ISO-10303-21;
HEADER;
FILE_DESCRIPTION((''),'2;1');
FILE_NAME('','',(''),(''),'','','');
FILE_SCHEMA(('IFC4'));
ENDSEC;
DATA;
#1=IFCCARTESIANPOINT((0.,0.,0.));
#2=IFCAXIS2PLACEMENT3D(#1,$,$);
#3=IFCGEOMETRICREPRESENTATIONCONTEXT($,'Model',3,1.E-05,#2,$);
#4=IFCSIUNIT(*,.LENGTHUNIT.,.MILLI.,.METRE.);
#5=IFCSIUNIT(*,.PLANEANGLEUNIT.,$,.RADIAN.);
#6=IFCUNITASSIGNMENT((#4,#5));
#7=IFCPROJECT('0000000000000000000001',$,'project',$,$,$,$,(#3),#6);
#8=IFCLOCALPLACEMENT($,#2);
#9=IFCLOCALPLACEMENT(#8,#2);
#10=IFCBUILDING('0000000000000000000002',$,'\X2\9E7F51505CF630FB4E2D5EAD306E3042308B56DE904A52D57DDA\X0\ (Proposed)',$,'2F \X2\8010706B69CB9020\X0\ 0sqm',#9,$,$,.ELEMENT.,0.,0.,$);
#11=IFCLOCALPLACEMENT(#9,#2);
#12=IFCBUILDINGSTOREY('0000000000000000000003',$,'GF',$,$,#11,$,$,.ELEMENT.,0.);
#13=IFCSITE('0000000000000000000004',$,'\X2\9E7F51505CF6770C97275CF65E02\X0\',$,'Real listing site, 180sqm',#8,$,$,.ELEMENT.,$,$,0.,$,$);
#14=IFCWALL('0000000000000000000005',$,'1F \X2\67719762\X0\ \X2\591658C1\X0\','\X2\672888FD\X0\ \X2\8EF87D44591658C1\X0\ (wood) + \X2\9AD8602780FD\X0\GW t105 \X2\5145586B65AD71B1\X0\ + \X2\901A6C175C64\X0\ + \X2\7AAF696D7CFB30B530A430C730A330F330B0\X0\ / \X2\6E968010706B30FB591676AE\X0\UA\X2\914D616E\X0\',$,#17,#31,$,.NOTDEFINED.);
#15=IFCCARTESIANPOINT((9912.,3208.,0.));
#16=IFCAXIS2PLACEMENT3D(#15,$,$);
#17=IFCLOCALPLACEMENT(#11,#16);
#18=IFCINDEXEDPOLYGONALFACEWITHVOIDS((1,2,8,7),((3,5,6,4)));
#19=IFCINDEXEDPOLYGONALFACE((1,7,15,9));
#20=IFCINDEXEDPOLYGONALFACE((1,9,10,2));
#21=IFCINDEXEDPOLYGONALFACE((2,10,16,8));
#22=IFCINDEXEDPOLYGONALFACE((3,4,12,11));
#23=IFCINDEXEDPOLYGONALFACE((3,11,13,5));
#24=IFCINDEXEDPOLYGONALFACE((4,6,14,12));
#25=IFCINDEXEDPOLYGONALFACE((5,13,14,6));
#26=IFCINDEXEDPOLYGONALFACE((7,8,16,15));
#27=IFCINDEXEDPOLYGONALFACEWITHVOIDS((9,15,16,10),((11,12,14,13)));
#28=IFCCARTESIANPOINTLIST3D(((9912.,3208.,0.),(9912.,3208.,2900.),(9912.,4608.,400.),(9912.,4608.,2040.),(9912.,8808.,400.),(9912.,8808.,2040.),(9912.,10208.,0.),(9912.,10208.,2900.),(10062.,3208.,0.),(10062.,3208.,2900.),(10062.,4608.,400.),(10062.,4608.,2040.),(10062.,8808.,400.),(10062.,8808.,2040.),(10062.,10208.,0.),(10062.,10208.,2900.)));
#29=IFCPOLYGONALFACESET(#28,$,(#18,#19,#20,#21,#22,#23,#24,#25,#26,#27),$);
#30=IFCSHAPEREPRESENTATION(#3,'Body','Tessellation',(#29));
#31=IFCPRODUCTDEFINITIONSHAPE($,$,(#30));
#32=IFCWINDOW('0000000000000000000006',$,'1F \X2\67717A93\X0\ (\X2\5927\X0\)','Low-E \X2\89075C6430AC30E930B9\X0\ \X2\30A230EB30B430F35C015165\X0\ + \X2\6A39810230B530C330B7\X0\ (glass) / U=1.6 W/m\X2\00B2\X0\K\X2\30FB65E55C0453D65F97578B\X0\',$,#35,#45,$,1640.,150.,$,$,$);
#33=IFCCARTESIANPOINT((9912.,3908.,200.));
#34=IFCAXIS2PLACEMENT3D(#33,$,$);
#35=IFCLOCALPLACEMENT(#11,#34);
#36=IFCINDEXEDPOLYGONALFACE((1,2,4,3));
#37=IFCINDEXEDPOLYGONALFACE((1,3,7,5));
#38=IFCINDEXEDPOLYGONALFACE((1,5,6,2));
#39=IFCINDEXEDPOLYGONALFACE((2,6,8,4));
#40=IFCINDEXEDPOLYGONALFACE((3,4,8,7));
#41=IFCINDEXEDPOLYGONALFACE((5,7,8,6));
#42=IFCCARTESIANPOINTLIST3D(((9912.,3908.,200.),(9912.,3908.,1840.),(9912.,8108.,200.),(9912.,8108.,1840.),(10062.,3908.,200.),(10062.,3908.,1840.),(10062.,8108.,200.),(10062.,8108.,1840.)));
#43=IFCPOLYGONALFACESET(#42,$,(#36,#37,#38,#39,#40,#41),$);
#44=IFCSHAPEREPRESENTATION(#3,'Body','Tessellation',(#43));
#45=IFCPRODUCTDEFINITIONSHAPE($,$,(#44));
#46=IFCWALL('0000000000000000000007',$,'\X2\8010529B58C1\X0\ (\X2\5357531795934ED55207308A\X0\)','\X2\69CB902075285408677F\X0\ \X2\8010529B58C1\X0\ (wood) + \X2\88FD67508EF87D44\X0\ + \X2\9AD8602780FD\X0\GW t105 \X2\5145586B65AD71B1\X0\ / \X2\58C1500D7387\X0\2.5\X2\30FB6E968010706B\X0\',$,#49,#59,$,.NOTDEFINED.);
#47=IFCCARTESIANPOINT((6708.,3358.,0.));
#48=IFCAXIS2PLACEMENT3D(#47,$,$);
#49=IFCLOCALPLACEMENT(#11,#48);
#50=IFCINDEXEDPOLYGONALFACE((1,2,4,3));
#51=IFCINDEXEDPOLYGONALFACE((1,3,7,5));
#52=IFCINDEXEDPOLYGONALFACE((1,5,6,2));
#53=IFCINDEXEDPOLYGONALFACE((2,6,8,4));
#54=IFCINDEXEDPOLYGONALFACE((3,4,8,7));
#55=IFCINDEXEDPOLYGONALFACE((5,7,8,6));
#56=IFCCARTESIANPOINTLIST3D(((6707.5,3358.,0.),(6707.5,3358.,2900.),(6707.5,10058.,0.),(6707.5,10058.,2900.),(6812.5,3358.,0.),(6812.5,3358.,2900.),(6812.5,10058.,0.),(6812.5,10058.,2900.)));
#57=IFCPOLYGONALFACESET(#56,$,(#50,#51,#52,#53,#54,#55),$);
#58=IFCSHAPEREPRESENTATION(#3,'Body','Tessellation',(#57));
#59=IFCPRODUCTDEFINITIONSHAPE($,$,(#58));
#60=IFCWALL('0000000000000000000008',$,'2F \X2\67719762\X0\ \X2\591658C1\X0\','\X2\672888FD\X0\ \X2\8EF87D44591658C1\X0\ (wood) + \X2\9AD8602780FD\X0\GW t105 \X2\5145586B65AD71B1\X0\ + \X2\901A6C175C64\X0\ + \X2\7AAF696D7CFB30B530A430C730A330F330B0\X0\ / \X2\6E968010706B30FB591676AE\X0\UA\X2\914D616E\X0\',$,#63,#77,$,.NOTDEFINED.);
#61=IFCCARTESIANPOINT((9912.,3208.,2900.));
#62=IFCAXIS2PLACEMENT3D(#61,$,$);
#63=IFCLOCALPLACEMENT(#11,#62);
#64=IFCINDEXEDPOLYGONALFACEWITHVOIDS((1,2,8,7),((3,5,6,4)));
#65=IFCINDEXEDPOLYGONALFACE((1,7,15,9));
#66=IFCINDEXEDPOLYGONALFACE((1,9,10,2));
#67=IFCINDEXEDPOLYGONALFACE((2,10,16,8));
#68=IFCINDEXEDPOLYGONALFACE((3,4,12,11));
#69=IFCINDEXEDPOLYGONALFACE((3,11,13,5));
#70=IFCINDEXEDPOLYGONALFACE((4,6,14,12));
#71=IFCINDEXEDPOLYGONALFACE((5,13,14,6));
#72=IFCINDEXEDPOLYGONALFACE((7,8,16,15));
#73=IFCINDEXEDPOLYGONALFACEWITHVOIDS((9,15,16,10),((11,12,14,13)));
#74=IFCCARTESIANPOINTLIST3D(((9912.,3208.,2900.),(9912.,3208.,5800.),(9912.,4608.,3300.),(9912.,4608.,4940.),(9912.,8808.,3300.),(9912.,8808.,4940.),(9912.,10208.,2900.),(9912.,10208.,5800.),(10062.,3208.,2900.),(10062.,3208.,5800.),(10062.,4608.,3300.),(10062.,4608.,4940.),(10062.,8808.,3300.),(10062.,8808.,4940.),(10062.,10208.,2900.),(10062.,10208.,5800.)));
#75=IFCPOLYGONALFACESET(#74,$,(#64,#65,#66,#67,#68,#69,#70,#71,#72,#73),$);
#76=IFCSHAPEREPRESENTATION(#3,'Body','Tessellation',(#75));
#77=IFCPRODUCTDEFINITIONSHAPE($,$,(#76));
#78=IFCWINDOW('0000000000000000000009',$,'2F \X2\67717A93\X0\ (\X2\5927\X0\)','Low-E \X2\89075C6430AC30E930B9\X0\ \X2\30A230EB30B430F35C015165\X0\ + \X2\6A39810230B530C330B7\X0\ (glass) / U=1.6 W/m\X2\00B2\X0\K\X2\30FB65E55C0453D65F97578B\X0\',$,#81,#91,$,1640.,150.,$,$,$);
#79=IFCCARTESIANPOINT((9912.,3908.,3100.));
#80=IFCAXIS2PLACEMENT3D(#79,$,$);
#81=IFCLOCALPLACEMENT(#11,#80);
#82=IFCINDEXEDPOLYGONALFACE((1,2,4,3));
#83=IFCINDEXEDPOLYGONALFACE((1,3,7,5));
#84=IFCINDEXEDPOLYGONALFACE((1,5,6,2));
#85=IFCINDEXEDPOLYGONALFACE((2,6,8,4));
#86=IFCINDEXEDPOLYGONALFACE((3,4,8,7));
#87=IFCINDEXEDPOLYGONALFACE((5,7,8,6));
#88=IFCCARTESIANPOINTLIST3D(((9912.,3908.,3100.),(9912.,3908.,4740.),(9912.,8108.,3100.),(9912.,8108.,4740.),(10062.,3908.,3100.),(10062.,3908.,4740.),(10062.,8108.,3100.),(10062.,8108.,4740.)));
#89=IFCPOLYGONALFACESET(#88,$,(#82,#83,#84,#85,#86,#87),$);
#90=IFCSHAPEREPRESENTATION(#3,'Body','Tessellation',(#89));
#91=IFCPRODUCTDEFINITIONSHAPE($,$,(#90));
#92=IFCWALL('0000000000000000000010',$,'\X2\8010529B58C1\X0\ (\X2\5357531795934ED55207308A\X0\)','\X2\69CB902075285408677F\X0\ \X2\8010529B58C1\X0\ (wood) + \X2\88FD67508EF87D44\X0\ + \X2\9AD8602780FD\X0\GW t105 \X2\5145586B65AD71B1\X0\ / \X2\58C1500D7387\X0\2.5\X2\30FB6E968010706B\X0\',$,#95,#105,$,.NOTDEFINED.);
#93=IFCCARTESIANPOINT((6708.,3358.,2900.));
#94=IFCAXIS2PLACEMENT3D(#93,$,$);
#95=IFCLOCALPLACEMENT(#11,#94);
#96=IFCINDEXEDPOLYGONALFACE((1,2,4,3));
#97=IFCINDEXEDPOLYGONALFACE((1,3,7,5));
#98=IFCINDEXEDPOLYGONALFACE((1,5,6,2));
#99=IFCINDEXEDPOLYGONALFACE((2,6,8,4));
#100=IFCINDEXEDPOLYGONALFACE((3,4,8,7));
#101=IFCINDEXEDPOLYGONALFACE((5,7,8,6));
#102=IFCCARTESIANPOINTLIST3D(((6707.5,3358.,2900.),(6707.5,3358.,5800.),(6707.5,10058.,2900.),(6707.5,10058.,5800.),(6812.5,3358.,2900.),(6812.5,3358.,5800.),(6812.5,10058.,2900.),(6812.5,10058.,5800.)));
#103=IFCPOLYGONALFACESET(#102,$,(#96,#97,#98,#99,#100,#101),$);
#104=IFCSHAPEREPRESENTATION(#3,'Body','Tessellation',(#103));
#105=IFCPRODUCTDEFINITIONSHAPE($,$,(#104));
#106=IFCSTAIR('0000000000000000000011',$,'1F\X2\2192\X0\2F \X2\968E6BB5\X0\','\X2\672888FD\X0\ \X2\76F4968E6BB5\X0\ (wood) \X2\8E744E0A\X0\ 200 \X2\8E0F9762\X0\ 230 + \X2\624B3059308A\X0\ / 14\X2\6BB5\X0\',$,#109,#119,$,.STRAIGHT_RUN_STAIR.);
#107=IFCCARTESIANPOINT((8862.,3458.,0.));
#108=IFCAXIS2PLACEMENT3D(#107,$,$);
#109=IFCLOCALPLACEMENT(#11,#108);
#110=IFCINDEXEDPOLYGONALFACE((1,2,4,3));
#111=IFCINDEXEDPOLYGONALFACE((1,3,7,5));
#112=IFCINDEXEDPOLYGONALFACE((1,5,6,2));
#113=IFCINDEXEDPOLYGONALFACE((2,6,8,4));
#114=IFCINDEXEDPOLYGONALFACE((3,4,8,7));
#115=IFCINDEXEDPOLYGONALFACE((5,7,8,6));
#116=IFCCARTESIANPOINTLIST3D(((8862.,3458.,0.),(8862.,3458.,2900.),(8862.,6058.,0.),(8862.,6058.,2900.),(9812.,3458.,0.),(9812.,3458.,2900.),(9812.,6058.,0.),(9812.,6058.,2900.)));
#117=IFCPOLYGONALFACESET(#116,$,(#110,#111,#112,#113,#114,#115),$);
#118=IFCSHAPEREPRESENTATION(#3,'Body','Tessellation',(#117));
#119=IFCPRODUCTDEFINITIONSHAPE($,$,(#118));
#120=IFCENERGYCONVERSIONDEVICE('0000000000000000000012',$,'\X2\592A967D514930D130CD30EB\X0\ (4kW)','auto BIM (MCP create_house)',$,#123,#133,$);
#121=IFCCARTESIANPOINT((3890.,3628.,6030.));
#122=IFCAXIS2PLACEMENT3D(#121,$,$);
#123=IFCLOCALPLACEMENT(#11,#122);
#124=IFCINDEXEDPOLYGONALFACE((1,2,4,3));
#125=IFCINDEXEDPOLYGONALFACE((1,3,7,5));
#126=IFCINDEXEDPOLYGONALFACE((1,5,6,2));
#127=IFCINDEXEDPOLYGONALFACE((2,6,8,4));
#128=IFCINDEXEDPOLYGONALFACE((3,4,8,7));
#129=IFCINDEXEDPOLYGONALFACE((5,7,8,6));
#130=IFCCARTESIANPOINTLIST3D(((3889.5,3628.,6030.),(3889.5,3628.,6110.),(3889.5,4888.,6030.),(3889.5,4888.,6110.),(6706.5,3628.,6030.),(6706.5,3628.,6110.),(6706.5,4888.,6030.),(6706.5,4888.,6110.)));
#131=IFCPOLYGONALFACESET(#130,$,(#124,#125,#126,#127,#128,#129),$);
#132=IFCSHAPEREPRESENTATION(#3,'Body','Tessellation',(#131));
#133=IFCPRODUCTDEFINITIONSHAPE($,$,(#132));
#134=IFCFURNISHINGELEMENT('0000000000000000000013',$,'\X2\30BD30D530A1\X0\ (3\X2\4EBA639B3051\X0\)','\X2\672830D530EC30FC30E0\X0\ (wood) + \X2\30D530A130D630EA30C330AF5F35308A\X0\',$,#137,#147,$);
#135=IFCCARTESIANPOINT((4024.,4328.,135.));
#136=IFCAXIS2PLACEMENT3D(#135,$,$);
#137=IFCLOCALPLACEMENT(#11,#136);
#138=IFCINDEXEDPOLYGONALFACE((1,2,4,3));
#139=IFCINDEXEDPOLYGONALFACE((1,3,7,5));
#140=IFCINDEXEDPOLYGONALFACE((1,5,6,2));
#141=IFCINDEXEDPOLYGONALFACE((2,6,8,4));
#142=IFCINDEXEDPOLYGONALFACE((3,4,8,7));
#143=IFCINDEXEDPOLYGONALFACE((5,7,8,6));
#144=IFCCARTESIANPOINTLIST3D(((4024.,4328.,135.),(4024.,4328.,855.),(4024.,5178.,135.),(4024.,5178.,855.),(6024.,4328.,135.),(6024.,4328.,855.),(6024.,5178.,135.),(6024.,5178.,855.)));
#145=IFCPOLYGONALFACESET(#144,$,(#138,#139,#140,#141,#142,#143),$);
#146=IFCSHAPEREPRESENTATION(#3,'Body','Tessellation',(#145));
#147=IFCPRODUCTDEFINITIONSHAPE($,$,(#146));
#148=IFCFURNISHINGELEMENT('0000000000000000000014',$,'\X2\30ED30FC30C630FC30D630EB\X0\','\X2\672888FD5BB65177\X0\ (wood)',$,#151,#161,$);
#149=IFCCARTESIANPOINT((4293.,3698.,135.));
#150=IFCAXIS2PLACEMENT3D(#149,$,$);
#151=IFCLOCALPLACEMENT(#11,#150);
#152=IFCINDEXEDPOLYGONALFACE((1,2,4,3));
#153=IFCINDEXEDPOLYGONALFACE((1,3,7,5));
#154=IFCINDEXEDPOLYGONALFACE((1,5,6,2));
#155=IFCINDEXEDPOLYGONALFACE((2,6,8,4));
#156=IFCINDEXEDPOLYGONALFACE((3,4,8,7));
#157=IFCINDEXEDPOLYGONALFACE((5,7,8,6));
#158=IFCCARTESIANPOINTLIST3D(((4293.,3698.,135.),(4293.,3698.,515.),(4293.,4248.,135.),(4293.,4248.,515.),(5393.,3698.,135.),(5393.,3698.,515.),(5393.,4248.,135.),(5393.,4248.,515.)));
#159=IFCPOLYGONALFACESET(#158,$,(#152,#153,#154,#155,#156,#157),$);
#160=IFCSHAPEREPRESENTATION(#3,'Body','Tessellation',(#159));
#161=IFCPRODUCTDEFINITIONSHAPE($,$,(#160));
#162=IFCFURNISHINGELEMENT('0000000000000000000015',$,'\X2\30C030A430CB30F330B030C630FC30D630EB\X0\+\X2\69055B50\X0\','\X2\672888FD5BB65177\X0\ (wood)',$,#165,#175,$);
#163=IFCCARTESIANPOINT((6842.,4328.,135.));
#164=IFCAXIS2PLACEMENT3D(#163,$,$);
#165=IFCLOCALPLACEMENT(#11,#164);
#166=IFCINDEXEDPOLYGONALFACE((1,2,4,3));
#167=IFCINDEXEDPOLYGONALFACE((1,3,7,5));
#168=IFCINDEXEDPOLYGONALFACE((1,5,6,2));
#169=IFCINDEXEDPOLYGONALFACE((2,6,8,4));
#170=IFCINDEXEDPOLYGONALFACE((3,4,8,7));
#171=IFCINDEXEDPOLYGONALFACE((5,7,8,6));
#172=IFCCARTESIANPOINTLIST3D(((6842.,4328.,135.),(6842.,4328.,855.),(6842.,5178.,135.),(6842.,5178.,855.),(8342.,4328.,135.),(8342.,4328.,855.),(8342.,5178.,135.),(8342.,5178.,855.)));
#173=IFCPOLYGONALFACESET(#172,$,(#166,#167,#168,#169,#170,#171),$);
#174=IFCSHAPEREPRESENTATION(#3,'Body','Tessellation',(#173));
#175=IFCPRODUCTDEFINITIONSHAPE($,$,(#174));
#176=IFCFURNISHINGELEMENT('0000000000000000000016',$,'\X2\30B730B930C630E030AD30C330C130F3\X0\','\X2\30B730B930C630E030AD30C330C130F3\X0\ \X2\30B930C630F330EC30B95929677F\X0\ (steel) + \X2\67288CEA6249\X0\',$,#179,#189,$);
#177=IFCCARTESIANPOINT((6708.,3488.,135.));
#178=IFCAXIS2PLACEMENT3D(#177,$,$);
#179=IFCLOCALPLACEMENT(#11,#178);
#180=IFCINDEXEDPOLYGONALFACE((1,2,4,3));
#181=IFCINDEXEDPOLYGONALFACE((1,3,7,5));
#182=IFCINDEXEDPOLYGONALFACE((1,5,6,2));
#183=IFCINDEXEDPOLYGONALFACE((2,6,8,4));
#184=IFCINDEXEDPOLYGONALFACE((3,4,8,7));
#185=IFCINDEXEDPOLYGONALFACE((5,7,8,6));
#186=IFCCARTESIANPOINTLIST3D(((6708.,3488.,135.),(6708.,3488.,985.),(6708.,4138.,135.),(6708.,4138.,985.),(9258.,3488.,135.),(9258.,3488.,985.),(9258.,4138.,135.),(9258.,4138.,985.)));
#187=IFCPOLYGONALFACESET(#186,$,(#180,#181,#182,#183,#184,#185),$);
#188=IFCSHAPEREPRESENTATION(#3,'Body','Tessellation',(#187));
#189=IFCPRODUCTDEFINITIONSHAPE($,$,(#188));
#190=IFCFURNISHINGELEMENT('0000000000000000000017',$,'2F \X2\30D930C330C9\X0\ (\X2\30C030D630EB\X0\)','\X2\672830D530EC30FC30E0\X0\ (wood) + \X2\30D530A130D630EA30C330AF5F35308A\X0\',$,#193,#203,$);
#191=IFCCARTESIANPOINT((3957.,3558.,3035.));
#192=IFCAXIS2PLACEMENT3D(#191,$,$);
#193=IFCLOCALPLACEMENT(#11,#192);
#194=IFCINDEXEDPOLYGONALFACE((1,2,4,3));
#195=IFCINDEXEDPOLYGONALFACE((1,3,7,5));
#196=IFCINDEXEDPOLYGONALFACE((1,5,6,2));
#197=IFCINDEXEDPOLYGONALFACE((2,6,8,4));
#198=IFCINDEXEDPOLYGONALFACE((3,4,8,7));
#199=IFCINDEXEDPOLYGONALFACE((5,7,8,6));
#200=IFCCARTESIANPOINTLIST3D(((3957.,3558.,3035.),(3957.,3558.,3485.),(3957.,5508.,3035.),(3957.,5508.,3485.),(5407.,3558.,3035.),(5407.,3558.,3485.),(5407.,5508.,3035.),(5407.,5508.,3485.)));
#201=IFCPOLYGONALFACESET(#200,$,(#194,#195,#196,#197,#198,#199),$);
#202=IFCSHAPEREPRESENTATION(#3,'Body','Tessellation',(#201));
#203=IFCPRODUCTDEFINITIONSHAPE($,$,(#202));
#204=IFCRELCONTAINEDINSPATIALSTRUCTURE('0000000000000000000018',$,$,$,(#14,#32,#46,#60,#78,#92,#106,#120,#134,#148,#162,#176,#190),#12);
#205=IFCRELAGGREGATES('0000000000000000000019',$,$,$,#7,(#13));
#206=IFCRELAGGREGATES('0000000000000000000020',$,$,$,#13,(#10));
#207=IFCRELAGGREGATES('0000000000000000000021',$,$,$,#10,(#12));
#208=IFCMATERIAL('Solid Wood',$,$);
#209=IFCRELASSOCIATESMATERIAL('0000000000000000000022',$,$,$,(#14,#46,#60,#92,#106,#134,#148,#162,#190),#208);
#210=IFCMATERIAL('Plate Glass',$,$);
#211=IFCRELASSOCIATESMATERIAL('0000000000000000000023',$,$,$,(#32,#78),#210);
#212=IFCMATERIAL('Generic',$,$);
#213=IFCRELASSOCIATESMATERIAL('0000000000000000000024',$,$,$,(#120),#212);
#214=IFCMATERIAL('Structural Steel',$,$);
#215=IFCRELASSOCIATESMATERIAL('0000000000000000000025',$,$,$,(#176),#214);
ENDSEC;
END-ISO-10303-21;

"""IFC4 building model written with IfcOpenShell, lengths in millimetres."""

from ifc_helpers import new_model, si_unit, frame, frame_2d, origin, place, context, project, spatial, rectangle, extrude, material, element, fill, save


model = new_model("IFC4")

# Units and contexts
model_context = context("Model", 3, precision=1e-05, world=origin())
ifc_project = project(units=[si_unit("LENGTHUNIT", "METRE", prefix="MILLI"), si_unit("PLANEANGLEUNIT", "RADIAN")], contexts=[model_context])

# Site, building, storey
site_placement = place(None, origin())
site = spatial("IfcSite", under=ifc_project, at=site_placement, Name="鹿児島県霧島市", ObjectType="Real listing site, 180sqm", CompositionType="ELEMENT", RefElevation=0.0)
building_placement = place(site_placement, origin())
building = spatial("IfcBuilding", under=site, at=building_placement, Name="鹿児島・中庭のある回遊動線 (Proposed)", ObjectType="2F 耐火構造 0sqm", CompositionType="ELEMENT", ElevationOfRefHeight=0.0, ElevationOfTerrain=0.0)
storey_placement = place(building_placement, origin())
storey = spatial("IfcBuildingStorey", under=building, at=storey_placement, Name="GF", CompositionType="ELEMENT", Elevation=0.0)

# Wall, opening, window
ifc_material_1 = material(Name="Solid Wood")
wall_1_placement = place(storey_placement, frame((9912.0, 3208.0, 0.0)))
wall_1 = element("IfcWall", 1, at=wall_1_placement, inside=storey, material=ifc_material_1, Name="1F 東面 外壁", Description="木製 軸組外壁 (wood) + 高性能GW t105 充填断熱 + 通気層 + 窯業系サイディング / 準耐火・外皮UA配慮", PredefinedType="NOTDEFINED", context=model_context, shape_type="SweptSolid", body=[
    extrude(rectangle(XDim=150.0, YDim=7000.0, at=frame_2d((75.0, 3500.0))), frame((9912.0, 3208.0, 0.0)), (0.0, 0.0, 1.0), 2900.0),
])
opening_1_placement = place(storey_placement, frame((9912.0, 3908.0, 200.0)))
opening_1 = element("IfcOpeningElement", 2, at=opening_1_placement, cuts=wall_1, PredefinedType="NOTDEFINED", context=model_context, shape_type="SweptSolid", body=[
    extrude(rectangle(XDim=150.0, YDim=4200.0, at=frame_2d((75.0, 2100.0))), frame((9912.0, 3908.0, 200.0)), (0.0, 0.0, 1.0), 1640.0),
])
ifc_material_2 = material(Name="Plate Glass")
window_1_placement = place(storey_placement, frame((9912.0, 3908.0, 200.0)))
window_1 = element("IfcWindow", 3, at=window_1_placement, inside=storey, material=ifc_material_2, Name="1F 東窓 (大)", Description="Low-E 複層ガラス アルゴン封入 + 樹脂サッシ (glass) / U=1.6 W/m²K・日射取得型", OverallHeight=1640.0, OverallWidth=150.0, context=model_context, shape_type="SweptSolid", body=[
    extrude(rectangle(XDim=150.0, YDim=4200.0, at=frame_2d((75.0, 2100.0))), frame((9912.0, 3908.0, 200.0)), (0.0, 0.0, 1.0), 1640.0),
])
fill(opening_1, window_1)

# Wall
wall_2_placement = place(storey_placement, frame((6708.0, 3358.0, 0.0)))
element("IfcWall", 4, at=wall_2_placement, inside=storey, material=ifc_material_1, Name="耐力壁 (南北間仕切り)", Description="構造用合板 耐力壁 (wood) + 製材軸組 + 高性能GW t105 充填断熱 / 壁倍率2.5・準耐火", PredefinedType="NOTDEFINED", context=model_context, shape_type="SweptSolid", body=[
    extrude(rectangle(XDim=105.0, YDim=6700.0, at=frame_2d((52.0, 3350.0))), frame((6708.0, 3358.0, 0.0)), (0.0, 0.0, 1.0), 2900.0),
])

# Wall, opening, window
wall_3_placement = place(storey_placement, frame((9912.0, 3208.0, 2900.0)))
wall_3 = element("IfcWall", 5, at=wall_3_placement, inside=storey, material=ifc_material_1, Name="2F 東面 外壁", Description="木製 軸組外壁 (wood) + 高性能GW t105 充填断熱 + 通気層 + 窯業系サイディング / 準耐火・外皮UA配慮", PredefinedType="NOTDEFINED", context=model_context, shape_type="SweptSolid", body=[
    extrude(rectangle(XDim=150.0, YDim=7000.0, at=frame_2d((75.0, 3500.0))), frame((9912.0, 3208.0, 2900.0)), (0.0, 0.0, 1.0), 2900.0),
])
opening_2_placement = place(storey_placement, frame((9912.0, 3908.0, 3100.0)))
opening_2 = element("IfcOpeningElement", 6, at=opening_2_placement, cuts=wall_3, PredefinedType="NOTDEFINED", context=model_context, shape_type="SweptSolid", body=[
    extrude(rectangle(XDim=150.0, YDim=4200.0, at=frame_2d((75.0, 2100.0))), frame((9912.0, 3908.0, 3100.0)), (0.0, 0.0, 1.0), 1640.0),
])
window_2_placement = place(storey_placement, frame((9912.0, 3908.0, 3100.0)))
window_2 = element("IfcWindow", 7, at=window_2_placement, inside=storey, material=ifc_material_2, Name="2F 東窓 (大)", Description="Low-E 複層ガラス アルゴン封入 + 樹脂サッシ (glass) / U=1.6 W/m²K・日射取得型", OverallHeight=1640.0, OverallWidth=150.0, context=model_context, shape_type="SweptSolid", body=[
    extrude(rectangle(XDim=150.0, YDim=4200.0, at=frame_2d((75.0, 2100.0))), frame((9912.0, 3908.0, 3100.0)), (0.0, 0.0, 1.0), 1640.0),
])
fill(opening_2, window_2)

# Wall
wall_4_placement = place(storey_placement, frame((6708.0, 3358.0, 2900.0)))
element("IfcWall", 8, at=wall_4_placement, inside=storey, material=ifc_material_1, Name="耐力壁 (南北間仕切り)", Description="構造用合板 耐力壁 (wood) + 製材軸組 + 高性能GW t105 充填断熱 / 壁倍率2.5・準耐火", PredefinedType="NOTDEFINED", context=model_context, shape_type="SweptSolid", body=[
    extrude(rectangle(XDim=105.0, YDim=6700.0, at=frame_2d((52.0, 3350.0))), frame((6708.0, 3358.0, 2900.0)), (0.0, 0.0, 1.0), 2900.0),
])

# Stair
stair_placement = place(storey_placement, frame((8862.0, 3458.0, 0.0)))
element("IfcStair", 9, at=stair_placement, inside=storey, material=ifc_material_1, Name="1F→2F 階段", Description="木製 直階段 (wood) 蹴上 200 踏面 230 + 手すり / 14段", PredefinedType="STRAIGHT_RUN_STAIR", context=model_context, shape_type="SweptSolid", body=[
    extrude(rectangle(XDim=950.0, YDim=2600.0, at=frame_2d((475.0, 1300.0))), frame((8862.0, 3458.0, 0.0)), (0.0, 0.0, 1.0), 2900.0),
])

# Energy conversion device
ifc_material_3 = material(Name="Generic")
energy_conversion_device_placement = place(storey_placement, frame((3890.0, 3628.0, 6030.0)))
element("IfcEnergyConversionDevice", 10, at=energy_conversion_device_placement, inside=storey, material=ifc_material_3, Name="太陽光パネル (4kW)", Description="auto BIM (MCP create_house)", context=model_context, shape_type="SweptSolid", body=[
    extrude(rectangle(XDim=2817.0, YDim=1260.0, at=frame_2d((1408.0, 630.0))), frame((3890.0, 3628.0, 6030.0)), (0.0, 0.0, 1.0), 80.0),
])

# Furnishing elements
furnishing_1_placement = place(storey_placement, frame((4024.0, 4328.0, 135.0)))
element("IfcFurnishingElement", 11, at=furnishing_1_placement, inside=storey, material=ifc_material_1, Name="ソファ (3人掛け)", Description="木フレーム (wood) + ファブリック張り", context=model_context, shape_type="SweptSolid", body=[
    extrude(rectangle(XDim=2000.0, YDim=850.0, at=frame_2d((1000.0, 425.0))), frame((4024.0, 4328.0, 135.0)), (0.0, 0.0, 1.0), 720.0),
])
furnishing_2_placement = place(storey_placement, frame((4293.0, 3698.0, 135.0)))
element("IfcFurnishingElement", 12, at=furnishing_2_placement, inside=storey, material=ifc_material_1, Name="ローテーブル", Description="木製家具 (wood)", context=model_context, shape_type="SweptSolid", body=[
    extrude(rectangle(XDim=1100.0, YDim=550.0, at=frame_2d((550.0, 275.0))), frame((4293.0, 3698.0, 135.0)), (0.0, 0.0, 1.0), 380.0),
])
furnishing_3_placement = place(storey_placement, frame((6842.0, 4328.0, 135.0)))
element("IfcFurnishingElement", 13, at=furnishing_3_placement, inside=storey, material=ifc_material_1, Name="ダイニングテーブル+椅子", Description="木製家具 (wood)", context=model_context, shape_type="SweptSolid", body=[
    extrude(rectangle(XDim=1500.0, YDim=850.0, at=frame_2d((750.0, 425.0))), frame((6842.0, 4328.0, 135.0)), (0.0, 0.0, 1.0), 720.0),
])
ifc_material_4 = material(Name="Structural Steel")
furnishing_4_placement = place(storey_placement, frame((6708.0, 3488.0, 135.0)))
element("IfcFurnishingElement", 14, at=furnishing_4_placement, inside=storey, material=ifc_material_4, Name="システムキッチン", Description="システムキッチン ステンレス天板 (steel) + 木質扉", context=model_context, shape_type="SweptSolid", body=[
    extrude(rectangle(XDim=2550.0, YDim=650.0, at=frame_2d((1275.0, 325.0))), frame((6708.0, 3488.0, 135.0)), (0.0, 0.0, 1.0), 850.0),
])
furnishing_5_placement = place(storey_placement, frame((3957.0, 3558.0, 3035.0)))
element("IfcFurnishingElement", 15, at=furnishing_5_placement, inside=storey, material=ifc_material_1, Name="2F ベッド (ダブル)", Description="木フレーム (wood) + ファブリック張り", context=model_context, shape_type="SweptSolid", body=[
    extrude(rectangle(XDim=1450.0, YDim=1950.0, at=frame_2d((725.0, 975.0))), frame((3957.0, 3558.0, 3035.0)), (0.0, 0.0, 1.0), 450.0),
])

save(model, "model.ifc")
